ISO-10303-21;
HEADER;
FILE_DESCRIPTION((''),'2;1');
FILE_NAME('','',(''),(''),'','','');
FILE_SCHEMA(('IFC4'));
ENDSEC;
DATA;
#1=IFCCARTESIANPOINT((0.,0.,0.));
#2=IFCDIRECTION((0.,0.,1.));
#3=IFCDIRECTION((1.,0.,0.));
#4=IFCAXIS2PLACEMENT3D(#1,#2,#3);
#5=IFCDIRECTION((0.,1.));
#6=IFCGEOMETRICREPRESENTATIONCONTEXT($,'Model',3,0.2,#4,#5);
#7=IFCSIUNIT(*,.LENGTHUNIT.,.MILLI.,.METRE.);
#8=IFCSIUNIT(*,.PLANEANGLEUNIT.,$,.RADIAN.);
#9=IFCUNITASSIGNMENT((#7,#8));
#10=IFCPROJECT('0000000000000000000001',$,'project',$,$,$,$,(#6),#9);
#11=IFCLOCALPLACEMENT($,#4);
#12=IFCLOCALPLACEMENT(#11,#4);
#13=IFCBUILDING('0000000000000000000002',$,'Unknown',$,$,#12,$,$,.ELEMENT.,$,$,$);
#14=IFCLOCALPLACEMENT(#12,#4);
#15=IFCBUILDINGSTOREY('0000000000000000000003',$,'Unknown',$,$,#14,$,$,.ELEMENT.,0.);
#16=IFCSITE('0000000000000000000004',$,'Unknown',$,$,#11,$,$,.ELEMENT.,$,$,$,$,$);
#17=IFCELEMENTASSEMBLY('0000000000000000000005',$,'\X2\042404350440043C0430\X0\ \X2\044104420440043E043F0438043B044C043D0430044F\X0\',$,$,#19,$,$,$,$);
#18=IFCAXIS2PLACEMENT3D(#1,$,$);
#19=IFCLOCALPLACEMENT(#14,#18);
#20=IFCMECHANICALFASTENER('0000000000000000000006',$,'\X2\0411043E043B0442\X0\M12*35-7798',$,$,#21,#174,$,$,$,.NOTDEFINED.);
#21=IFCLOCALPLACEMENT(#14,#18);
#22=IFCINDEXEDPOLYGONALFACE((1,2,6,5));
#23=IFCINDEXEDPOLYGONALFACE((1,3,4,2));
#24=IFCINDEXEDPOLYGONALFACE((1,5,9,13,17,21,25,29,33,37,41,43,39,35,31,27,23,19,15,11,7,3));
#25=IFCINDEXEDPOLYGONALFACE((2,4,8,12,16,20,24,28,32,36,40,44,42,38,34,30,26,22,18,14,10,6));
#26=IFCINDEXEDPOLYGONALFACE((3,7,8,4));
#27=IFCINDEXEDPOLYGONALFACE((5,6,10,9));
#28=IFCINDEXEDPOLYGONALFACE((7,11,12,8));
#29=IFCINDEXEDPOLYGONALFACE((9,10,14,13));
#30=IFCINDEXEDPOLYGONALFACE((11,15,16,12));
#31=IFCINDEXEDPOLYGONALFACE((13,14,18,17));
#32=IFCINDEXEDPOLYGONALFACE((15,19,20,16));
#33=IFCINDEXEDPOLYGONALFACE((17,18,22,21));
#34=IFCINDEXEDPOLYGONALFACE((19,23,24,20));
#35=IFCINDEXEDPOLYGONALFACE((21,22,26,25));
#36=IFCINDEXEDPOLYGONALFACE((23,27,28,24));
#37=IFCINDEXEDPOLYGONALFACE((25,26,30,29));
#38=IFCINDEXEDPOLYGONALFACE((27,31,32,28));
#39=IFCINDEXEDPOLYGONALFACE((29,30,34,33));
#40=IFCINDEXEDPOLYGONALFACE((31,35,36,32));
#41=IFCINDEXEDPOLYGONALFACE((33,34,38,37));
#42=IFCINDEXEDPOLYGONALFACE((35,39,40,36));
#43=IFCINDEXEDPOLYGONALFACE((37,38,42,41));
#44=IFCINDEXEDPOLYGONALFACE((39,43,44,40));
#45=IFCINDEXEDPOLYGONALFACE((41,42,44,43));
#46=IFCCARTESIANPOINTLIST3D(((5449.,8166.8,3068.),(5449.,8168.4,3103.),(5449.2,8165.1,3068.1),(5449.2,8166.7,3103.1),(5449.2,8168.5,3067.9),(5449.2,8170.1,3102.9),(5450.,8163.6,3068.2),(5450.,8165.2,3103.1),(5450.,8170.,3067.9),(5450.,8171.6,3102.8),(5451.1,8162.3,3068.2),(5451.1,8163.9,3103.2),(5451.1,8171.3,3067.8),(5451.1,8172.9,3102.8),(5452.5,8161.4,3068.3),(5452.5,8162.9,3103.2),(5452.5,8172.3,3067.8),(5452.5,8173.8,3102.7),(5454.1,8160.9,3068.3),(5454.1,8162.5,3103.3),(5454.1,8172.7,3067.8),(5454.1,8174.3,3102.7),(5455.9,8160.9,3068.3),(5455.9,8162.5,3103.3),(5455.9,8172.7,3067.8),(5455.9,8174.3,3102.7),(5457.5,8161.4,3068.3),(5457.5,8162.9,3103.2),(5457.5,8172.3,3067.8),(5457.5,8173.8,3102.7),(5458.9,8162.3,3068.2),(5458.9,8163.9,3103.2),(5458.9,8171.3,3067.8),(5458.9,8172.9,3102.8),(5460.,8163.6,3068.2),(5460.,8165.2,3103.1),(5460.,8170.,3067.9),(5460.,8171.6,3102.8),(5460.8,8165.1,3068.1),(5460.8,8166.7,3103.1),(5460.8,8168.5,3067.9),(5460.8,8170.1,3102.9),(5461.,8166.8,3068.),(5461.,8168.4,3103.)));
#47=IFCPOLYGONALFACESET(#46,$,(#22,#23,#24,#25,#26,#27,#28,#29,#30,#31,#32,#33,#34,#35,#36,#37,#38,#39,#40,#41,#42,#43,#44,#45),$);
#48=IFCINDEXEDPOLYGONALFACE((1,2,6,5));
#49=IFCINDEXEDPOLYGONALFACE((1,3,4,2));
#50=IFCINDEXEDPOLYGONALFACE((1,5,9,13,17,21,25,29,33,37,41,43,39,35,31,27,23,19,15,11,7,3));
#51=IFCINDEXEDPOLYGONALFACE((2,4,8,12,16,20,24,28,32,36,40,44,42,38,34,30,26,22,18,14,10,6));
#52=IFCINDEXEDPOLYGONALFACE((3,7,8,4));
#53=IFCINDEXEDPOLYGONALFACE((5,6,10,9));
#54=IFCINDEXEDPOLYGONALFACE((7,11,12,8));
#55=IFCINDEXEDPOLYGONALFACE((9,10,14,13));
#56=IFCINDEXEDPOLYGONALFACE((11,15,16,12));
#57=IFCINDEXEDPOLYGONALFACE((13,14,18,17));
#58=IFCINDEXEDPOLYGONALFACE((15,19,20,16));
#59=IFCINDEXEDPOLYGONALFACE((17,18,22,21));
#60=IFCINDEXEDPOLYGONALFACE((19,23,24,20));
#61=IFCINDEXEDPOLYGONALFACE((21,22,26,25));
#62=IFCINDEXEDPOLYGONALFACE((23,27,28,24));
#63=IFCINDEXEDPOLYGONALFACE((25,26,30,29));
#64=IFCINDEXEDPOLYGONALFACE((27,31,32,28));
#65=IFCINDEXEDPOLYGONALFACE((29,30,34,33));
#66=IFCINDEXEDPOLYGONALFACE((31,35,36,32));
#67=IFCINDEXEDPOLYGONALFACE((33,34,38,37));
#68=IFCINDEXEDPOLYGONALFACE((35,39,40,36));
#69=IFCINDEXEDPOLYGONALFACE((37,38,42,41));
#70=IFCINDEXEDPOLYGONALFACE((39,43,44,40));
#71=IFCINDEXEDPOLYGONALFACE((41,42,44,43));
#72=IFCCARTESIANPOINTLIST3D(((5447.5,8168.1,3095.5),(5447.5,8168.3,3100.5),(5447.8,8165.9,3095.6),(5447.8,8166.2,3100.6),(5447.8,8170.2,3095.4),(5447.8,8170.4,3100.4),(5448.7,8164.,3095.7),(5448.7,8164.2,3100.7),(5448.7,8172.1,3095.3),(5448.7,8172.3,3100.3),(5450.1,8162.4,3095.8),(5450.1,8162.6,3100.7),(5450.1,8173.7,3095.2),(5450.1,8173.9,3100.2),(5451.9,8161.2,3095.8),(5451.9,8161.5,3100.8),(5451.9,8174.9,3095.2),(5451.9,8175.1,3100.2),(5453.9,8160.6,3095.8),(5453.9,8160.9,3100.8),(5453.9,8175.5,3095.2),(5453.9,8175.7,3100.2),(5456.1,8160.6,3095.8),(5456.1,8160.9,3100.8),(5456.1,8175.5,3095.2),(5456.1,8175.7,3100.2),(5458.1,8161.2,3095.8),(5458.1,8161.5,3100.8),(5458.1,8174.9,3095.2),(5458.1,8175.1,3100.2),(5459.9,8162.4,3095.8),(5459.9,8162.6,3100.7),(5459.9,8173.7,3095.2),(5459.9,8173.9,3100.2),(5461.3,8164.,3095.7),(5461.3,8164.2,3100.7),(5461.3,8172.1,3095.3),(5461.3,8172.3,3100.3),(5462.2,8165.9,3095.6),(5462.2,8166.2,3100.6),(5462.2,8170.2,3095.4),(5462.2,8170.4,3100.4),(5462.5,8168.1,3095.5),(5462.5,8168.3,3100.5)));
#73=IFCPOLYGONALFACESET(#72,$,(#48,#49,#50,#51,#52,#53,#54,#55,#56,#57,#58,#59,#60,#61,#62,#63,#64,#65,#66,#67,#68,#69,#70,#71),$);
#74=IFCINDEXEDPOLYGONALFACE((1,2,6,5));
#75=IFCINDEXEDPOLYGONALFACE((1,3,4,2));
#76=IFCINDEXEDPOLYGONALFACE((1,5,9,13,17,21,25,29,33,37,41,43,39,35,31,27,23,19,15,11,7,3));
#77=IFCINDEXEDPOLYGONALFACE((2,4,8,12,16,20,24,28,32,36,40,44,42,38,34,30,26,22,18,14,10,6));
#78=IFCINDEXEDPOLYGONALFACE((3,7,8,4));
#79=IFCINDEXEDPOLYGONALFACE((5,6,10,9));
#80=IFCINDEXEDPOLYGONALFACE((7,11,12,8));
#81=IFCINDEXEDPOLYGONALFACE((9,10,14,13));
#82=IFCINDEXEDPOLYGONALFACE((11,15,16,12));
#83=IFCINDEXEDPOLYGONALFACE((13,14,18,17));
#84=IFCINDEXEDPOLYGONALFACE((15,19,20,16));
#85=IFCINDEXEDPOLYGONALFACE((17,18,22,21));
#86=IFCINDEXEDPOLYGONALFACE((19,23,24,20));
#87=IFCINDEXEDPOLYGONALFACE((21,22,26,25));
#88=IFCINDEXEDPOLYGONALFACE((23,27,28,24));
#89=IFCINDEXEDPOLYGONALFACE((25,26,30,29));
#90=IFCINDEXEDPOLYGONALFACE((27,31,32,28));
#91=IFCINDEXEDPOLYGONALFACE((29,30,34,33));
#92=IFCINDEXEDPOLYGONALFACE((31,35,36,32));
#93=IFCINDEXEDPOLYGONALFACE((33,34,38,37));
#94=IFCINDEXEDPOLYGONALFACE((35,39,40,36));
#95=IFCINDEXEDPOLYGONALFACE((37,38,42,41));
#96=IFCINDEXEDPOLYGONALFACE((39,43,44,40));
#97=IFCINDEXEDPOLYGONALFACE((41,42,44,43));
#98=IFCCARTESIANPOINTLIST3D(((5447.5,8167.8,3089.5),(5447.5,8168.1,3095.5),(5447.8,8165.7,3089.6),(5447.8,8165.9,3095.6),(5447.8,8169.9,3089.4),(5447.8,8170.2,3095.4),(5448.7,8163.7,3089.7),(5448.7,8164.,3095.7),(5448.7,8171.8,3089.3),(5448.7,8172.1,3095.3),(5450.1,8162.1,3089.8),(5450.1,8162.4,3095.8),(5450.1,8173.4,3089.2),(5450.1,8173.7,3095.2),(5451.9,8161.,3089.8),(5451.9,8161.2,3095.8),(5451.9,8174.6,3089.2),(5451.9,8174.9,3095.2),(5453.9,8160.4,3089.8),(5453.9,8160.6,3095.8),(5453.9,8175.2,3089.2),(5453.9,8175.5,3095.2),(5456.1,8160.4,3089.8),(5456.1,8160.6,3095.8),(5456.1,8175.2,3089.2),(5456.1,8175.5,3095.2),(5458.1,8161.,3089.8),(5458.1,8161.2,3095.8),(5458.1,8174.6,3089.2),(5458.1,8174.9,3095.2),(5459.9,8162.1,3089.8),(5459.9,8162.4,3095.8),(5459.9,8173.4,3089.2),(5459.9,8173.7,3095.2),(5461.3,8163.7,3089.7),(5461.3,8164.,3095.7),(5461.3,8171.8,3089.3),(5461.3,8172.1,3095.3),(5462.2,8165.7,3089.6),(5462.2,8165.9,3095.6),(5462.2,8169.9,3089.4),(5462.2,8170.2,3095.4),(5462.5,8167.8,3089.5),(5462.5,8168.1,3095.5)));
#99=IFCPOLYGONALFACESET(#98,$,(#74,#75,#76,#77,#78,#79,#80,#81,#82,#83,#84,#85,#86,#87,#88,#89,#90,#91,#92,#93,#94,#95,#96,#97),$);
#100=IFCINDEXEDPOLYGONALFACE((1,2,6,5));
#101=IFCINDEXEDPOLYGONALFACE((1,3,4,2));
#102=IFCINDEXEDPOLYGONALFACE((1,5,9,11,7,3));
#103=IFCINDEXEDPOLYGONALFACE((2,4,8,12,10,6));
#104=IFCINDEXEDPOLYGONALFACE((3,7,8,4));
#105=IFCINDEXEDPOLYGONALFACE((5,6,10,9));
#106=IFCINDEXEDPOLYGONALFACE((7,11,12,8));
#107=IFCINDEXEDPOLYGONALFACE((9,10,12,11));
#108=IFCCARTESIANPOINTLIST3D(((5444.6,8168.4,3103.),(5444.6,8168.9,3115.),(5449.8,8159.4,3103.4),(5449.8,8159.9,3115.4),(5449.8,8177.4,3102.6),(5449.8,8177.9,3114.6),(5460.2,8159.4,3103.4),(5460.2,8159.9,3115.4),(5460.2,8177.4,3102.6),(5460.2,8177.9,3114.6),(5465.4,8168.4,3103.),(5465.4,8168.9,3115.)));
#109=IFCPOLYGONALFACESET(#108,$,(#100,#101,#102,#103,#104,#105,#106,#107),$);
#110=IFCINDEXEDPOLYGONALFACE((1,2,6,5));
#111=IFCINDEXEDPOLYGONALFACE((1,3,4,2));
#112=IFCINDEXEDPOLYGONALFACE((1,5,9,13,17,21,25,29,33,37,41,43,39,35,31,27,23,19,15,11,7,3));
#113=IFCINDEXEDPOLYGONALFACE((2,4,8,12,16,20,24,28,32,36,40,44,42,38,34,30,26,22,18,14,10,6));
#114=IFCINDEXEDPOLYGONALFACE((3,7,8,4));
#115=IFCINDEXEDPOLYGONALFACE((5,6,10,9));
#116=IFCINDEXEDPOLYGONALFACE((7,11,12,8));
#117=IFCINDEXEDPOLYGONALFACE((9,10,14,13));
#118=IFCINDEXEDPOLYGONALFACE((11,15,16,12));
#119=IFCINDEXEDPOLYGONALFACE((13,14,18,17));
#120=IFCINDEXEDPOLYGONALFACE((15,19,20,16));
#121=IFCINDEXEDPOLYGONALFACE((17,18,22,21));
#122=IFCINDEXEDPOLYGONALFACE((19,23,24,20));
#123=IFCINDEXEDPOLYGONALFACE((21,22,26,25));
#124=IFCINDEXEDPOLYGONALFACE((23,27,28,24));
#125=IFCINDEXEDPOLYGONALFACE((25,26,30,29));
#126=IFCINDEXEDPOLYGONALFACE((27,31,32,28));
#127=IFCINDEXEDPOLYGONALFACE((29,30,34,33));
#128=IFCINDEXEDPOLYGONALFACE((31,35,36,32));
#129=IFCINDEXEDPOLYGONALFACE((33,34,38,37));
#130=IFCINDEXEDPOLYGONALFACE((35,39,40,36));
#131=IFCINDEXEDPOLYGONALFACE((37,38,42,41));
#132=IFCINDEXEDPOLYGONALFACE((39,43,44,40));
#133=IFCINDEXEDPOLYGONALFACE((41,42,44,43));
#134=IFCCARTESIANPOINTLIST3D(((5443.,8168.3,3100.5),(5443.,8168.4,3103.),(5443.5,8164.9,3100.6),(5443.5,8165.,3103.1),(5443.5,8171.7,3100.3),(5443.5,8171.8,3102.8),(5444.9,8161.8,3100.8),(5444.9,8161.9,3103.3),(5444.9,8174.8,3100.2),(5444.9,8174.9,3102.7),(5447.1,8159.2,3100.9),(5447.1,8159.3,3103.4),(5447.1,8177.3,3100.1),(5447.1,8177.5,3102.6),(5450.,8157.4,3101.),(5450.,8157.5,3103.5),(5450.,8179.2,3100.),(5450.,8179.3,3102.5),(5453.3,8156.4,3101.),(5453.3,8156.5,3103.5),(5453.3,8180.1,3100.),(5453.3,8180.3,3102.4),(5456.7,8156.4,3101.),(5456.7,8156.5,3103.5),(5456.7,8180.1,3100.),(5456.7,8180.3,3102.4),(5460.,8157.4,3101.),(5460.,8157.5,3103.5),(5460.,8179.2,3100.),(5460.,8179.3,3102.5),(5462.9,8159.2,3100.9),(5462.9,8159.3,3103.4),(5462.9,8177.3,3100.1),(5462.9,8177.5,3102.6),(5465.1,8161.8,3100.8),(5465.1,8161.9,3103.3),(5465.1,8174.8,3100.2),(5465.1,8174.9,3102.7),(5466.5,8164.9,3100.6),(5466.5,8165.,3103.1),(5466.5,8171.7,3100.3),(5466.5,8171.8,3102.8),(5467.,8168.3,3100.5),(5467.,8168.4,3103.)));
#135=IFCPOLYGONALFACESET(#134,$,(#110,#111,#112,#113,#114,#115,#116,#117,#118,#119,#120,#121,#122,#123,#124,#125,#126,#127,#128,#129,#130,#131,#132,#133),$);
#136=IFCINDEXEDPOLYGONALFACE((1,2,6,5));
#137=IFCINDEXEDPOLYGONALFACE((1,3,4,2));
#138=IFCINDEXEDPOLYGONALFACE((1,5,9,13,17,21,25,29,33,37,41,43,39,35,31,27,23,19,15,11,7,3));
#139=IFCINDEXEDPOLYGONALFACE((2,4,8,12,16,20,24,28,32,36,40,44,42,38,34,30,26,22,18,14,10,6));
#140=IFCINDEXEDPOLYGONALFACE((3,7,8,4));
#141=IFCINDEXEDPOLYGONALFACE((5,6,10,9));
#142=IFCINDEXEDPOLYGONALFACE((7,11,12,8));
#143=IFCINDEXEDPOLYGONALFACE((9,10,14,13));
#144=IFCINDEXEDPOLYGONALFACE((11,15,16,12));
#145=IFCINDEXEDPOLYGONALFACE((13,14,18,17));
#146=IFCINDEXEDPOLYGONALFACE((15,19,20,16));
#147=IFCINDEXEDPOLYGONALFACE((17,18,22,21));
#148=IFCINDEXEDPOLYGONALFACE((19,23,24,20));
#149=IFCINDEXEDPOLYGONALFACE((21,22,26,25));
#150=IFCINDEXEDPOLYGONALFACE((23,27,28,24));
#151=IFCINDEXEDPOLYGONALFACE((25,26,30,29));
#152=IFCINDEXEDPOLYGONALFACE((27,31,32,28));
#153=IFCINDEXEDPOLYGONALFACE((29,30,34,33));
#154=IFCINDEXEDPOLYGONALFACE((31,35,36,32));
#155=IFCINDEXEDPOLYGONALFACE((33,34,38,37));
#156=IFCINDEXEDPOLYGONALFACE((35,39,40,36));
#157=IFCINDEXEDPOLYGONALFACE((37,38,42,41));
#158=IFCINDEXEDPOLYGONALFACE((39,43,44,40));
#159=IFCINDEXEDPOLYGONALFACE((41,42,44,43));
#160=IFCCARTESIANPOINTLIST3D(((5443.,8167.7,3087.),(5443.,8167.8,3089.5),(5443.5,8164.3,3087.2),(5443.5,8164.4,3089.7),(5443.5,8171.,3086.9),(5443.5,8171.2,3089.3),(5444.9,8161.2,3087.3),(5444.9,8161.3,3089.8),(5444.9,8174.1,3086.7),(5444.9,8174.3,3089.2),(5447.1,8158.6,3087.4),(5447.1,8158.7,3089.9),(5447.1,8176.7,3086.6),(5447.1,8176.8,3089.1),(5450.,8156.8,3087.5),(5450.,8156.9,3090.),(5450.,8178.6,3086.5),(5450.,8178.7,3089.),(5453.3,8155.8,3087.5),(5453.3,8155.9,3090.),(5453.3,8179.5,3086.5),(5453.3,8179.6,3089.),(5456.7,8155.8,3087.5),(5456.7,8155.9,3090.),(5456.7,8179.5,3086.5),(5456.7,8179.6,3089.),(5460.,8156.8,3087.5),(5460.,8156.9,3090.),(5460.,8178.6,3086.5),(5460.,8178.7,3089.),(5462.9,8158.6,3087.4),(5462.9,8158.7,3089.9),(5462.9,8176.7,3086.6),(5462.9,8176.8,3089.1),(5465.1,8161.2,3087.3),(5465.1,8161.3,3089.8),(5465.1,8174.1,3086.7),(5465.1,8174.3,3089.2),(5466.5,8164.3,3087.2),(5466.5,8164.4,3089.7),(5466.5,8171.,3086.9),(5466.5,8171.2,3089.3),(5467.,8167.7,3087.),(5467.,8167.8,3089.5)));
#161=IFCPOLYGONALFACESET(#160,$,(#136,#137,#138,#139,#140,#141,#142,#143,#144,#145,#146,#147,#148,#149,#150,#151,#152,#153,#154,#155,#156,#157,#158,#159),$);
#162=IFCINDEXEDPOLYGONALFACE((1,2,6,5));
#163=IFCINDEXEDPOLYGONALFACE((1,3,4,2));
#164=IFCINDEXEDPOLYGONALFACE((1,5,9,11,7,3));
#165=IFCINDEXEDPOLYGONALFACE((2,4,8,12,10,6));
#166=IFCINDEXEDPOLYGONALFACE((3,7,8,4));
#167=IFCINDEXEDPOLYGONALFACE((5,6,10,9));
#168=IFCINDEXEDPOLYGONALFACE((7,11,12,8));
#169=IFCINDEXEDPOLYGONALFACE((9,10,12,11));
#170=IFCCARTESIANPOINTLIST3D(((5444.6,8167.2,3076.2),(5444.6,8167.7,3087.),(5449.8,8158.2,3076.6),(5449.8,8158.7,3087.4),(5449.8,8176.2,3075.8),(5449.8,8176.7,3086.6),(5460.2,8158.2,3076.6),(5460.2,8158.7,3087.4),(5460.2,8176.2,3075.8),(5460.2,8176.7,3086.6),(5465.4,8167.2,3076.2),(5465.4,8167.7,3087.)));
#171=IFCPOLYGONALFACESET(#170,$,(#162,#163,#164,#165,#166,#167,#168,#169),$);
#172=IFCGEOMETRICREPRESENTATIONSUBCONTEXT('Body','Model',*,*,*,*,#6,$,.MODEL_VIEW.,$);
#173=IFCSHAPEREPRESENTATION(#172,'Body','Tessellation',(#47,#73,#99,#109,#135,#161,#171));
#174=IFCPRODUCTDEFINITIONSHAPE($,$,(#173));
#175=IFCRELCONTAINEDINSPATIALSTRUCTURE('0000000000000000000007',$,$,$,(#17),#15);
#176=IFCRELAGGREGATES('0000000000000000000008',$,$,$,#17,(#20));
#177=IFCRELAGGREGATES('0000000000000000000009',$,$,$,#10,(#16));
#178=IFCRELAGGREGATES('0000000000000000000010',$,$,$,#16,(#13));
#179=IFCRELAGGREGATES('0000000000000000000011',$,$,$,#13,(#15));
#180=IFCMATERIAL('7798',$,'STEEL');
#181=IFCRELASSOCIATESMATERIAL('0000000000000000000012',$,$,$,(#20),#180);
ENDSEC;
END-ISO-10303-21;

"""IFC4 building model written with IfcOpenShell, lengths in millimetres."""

from ifc_helpers import new_model, si_unit, direction, frame, origin_with_axes, place, context, subcontext, project, spatial, line, arc, indexed_curve, outline, extrude, source, transform, mapped, material, element, aggregate, save


model = new_model("IFC4")

# Units and contexts
model_context = context("Model", 3, precision=0.2, world=origin_with_axes(), true_north=direction((0.0, 1.0)))
body_context = subcontext(model_context, "Body", "Model", "MODEL_VIEW")
ifc_project = project(units=[si_unit("LENGTHUNIT", "METRE", prefix="MILLI"), si_unit("PLANEANGLEUNIT", "RADIAN")], contexts=[model_context])

# Site, building, storey
site_placement = place(None, origin_with_axes())
site = spatial("IfcSite", under=ifc_project, at=site_placement, Name="Unknown", CompositionType="ELEMENT")
building_placement = place(site_placement, origin_with_axes())
building = spatial("IfcBuilding", under=site, at=building_placement, Name="Unknown", CompositionType="ELEMENT")
storey_placement = place(building_placement, origin_with_axes())
storey = spatial("IfcBuildingStorey", under=building, at=storey_placement, Name="Unknown", CompositionType="ELEMENT", Elevation=0.0)

# Element assembly
assembly_1_placement = place(storey_placement, frame((5400.0, 88.6, 3426.7), z_axis=(1.0, 0.0, 0.0), x_axis=(0.0, 0.998969, -0.045408)))
assembly_1 = element("IfcElementAssembly", 1, at=assembly_1_placement, inside=storey, Name="Ферма стропильная")

# Mechanical fastener
ifc_material_1 = material(Name="7798", Category="STEEL")
shared_shape_1 = source(origin_with_axes(), body_context, "Body", "SweptSolid", [
    extrude(outline(indexed_curve([(6.0, 0.0), (0.0, 6.0), (-6.0, 0.0), (0.0, -6.0)], segments=[arc(1, 2, 3), arc(3, 4, 1)])), frame((0.0, 0.0, 7.5), z_axis=(0.0, 0.0, -1.0), x_axis=(0.0, 1.0, 0.0)), (0.0, 0.0, 1.0), 35.0),
    extrude(outline(indexed_curve([(7.5, 0.0), (0.0, 7.5), (-7.5, 0.0), (0.0, -7.5)], segments=[arc(1, 2, 3), arc(3, 4, 1)])), frame((0.0, 0.0, 5.0), z_axis=(0.0, 0.0, -1.0), x_axis=(0.0, 1.0, 0.0)), (0.0, 0.0, 1.0), 5.0),
    extrude(outline(indexed_curve([(7.5, 0.0), (0.0, 7.5), (-7.5, 0.0), (0.0, -7.5)], segments=[arc(1, 2, 3), arc(3, 4, 1)])), frame((0.0, 0.0, 0.0), z_axis=(0.0, 0.0, -1.0), x_axis=(0.0, 1.0, 0.0)), (0.0, 0.0, 1.0), 6.0),
    extrude(outline(indexed_curve([(10.4, 0.0), (5.2, 9.0), (-5.2, 9.0), (-10.4, 0.0), (-5.2, -9.0), (5.2, -9.0)], segments=[line(1, 2, 3, 4, 5, 6, 1)])), frame((0.0, 0.0, 19.5), z_axis=(0.0, 0.0, -1.0), x_axis=(0.0, 1.0, 0.0)), (0.0, 0.0, 1.0), 12.0),
    extrude(outline(indexed_curve([(12.0, 0.0), (0.0, 12.0), (-12.0, 0.0), (0.0, -12.0)], segments=[arc(1, 2, 3), arc(3, 4, 1)])), frame((0.0, 0.0, 7.5), z_axis=(0.0, 0.0, -1.0), x_axis=(0.0, 1.0, 0.0)), (0.0, 0.0, 1.0), 2.5),
    extrude(outline(indexed_curve([(12.0, 0.0), (0.0, 12.0), (-12.0, 0.0), (0.0, -12.0)], segments=[arc(1, 2, 3), arc(3, 4, 1)])), frame((0.0, 0.0, -6.0), z_axis=(0.0, 0.0, -1.0), x_axis=(0.0, 1.0, 0.0)), (0.0, 0.0, 1.0), 2.5),
    extrude(outline(indexed_curve([(10.4, 0.0), (5.2, 9.0), (-5.2, 9.0), (-10.4, 0.0), (-5.2, -9.0), (5.2, -9.0)], segments=[line(1, 2, 3, 4, 5, 6, 1)])), frame((0.0, 0.0, -8.5), z_axis=(0.0, 0.0, -1.0), x_axis=(0.0, 1.0, 0.0)), (0.0, 0.0, 1.0), 10.8),
])
mechanical_fastener_1_placement = place(assembly_1_placement, frame((8086.1, 36.0, 55.0), z_axis=(0.0, 1.0, 0.0), x_axis=(1.0, 0.0, 0.0)))
mechanical_fastener_1 = element("IfcMechanicalFastener", 2, at=mechanical_fastener_1_placement, material=ifc_material_1, Name="БолтM12*35-7798", PredefinedType="NOTDEFINED", context=body_context, shape_type="MappedRepresentation", body=[
    mapped(shared_shape_1, transform((0.0, 0.0, 0.0))),
])
aggregate(assembly_1, [mechanical_fastener_1])

save(model, "model.ifc")
